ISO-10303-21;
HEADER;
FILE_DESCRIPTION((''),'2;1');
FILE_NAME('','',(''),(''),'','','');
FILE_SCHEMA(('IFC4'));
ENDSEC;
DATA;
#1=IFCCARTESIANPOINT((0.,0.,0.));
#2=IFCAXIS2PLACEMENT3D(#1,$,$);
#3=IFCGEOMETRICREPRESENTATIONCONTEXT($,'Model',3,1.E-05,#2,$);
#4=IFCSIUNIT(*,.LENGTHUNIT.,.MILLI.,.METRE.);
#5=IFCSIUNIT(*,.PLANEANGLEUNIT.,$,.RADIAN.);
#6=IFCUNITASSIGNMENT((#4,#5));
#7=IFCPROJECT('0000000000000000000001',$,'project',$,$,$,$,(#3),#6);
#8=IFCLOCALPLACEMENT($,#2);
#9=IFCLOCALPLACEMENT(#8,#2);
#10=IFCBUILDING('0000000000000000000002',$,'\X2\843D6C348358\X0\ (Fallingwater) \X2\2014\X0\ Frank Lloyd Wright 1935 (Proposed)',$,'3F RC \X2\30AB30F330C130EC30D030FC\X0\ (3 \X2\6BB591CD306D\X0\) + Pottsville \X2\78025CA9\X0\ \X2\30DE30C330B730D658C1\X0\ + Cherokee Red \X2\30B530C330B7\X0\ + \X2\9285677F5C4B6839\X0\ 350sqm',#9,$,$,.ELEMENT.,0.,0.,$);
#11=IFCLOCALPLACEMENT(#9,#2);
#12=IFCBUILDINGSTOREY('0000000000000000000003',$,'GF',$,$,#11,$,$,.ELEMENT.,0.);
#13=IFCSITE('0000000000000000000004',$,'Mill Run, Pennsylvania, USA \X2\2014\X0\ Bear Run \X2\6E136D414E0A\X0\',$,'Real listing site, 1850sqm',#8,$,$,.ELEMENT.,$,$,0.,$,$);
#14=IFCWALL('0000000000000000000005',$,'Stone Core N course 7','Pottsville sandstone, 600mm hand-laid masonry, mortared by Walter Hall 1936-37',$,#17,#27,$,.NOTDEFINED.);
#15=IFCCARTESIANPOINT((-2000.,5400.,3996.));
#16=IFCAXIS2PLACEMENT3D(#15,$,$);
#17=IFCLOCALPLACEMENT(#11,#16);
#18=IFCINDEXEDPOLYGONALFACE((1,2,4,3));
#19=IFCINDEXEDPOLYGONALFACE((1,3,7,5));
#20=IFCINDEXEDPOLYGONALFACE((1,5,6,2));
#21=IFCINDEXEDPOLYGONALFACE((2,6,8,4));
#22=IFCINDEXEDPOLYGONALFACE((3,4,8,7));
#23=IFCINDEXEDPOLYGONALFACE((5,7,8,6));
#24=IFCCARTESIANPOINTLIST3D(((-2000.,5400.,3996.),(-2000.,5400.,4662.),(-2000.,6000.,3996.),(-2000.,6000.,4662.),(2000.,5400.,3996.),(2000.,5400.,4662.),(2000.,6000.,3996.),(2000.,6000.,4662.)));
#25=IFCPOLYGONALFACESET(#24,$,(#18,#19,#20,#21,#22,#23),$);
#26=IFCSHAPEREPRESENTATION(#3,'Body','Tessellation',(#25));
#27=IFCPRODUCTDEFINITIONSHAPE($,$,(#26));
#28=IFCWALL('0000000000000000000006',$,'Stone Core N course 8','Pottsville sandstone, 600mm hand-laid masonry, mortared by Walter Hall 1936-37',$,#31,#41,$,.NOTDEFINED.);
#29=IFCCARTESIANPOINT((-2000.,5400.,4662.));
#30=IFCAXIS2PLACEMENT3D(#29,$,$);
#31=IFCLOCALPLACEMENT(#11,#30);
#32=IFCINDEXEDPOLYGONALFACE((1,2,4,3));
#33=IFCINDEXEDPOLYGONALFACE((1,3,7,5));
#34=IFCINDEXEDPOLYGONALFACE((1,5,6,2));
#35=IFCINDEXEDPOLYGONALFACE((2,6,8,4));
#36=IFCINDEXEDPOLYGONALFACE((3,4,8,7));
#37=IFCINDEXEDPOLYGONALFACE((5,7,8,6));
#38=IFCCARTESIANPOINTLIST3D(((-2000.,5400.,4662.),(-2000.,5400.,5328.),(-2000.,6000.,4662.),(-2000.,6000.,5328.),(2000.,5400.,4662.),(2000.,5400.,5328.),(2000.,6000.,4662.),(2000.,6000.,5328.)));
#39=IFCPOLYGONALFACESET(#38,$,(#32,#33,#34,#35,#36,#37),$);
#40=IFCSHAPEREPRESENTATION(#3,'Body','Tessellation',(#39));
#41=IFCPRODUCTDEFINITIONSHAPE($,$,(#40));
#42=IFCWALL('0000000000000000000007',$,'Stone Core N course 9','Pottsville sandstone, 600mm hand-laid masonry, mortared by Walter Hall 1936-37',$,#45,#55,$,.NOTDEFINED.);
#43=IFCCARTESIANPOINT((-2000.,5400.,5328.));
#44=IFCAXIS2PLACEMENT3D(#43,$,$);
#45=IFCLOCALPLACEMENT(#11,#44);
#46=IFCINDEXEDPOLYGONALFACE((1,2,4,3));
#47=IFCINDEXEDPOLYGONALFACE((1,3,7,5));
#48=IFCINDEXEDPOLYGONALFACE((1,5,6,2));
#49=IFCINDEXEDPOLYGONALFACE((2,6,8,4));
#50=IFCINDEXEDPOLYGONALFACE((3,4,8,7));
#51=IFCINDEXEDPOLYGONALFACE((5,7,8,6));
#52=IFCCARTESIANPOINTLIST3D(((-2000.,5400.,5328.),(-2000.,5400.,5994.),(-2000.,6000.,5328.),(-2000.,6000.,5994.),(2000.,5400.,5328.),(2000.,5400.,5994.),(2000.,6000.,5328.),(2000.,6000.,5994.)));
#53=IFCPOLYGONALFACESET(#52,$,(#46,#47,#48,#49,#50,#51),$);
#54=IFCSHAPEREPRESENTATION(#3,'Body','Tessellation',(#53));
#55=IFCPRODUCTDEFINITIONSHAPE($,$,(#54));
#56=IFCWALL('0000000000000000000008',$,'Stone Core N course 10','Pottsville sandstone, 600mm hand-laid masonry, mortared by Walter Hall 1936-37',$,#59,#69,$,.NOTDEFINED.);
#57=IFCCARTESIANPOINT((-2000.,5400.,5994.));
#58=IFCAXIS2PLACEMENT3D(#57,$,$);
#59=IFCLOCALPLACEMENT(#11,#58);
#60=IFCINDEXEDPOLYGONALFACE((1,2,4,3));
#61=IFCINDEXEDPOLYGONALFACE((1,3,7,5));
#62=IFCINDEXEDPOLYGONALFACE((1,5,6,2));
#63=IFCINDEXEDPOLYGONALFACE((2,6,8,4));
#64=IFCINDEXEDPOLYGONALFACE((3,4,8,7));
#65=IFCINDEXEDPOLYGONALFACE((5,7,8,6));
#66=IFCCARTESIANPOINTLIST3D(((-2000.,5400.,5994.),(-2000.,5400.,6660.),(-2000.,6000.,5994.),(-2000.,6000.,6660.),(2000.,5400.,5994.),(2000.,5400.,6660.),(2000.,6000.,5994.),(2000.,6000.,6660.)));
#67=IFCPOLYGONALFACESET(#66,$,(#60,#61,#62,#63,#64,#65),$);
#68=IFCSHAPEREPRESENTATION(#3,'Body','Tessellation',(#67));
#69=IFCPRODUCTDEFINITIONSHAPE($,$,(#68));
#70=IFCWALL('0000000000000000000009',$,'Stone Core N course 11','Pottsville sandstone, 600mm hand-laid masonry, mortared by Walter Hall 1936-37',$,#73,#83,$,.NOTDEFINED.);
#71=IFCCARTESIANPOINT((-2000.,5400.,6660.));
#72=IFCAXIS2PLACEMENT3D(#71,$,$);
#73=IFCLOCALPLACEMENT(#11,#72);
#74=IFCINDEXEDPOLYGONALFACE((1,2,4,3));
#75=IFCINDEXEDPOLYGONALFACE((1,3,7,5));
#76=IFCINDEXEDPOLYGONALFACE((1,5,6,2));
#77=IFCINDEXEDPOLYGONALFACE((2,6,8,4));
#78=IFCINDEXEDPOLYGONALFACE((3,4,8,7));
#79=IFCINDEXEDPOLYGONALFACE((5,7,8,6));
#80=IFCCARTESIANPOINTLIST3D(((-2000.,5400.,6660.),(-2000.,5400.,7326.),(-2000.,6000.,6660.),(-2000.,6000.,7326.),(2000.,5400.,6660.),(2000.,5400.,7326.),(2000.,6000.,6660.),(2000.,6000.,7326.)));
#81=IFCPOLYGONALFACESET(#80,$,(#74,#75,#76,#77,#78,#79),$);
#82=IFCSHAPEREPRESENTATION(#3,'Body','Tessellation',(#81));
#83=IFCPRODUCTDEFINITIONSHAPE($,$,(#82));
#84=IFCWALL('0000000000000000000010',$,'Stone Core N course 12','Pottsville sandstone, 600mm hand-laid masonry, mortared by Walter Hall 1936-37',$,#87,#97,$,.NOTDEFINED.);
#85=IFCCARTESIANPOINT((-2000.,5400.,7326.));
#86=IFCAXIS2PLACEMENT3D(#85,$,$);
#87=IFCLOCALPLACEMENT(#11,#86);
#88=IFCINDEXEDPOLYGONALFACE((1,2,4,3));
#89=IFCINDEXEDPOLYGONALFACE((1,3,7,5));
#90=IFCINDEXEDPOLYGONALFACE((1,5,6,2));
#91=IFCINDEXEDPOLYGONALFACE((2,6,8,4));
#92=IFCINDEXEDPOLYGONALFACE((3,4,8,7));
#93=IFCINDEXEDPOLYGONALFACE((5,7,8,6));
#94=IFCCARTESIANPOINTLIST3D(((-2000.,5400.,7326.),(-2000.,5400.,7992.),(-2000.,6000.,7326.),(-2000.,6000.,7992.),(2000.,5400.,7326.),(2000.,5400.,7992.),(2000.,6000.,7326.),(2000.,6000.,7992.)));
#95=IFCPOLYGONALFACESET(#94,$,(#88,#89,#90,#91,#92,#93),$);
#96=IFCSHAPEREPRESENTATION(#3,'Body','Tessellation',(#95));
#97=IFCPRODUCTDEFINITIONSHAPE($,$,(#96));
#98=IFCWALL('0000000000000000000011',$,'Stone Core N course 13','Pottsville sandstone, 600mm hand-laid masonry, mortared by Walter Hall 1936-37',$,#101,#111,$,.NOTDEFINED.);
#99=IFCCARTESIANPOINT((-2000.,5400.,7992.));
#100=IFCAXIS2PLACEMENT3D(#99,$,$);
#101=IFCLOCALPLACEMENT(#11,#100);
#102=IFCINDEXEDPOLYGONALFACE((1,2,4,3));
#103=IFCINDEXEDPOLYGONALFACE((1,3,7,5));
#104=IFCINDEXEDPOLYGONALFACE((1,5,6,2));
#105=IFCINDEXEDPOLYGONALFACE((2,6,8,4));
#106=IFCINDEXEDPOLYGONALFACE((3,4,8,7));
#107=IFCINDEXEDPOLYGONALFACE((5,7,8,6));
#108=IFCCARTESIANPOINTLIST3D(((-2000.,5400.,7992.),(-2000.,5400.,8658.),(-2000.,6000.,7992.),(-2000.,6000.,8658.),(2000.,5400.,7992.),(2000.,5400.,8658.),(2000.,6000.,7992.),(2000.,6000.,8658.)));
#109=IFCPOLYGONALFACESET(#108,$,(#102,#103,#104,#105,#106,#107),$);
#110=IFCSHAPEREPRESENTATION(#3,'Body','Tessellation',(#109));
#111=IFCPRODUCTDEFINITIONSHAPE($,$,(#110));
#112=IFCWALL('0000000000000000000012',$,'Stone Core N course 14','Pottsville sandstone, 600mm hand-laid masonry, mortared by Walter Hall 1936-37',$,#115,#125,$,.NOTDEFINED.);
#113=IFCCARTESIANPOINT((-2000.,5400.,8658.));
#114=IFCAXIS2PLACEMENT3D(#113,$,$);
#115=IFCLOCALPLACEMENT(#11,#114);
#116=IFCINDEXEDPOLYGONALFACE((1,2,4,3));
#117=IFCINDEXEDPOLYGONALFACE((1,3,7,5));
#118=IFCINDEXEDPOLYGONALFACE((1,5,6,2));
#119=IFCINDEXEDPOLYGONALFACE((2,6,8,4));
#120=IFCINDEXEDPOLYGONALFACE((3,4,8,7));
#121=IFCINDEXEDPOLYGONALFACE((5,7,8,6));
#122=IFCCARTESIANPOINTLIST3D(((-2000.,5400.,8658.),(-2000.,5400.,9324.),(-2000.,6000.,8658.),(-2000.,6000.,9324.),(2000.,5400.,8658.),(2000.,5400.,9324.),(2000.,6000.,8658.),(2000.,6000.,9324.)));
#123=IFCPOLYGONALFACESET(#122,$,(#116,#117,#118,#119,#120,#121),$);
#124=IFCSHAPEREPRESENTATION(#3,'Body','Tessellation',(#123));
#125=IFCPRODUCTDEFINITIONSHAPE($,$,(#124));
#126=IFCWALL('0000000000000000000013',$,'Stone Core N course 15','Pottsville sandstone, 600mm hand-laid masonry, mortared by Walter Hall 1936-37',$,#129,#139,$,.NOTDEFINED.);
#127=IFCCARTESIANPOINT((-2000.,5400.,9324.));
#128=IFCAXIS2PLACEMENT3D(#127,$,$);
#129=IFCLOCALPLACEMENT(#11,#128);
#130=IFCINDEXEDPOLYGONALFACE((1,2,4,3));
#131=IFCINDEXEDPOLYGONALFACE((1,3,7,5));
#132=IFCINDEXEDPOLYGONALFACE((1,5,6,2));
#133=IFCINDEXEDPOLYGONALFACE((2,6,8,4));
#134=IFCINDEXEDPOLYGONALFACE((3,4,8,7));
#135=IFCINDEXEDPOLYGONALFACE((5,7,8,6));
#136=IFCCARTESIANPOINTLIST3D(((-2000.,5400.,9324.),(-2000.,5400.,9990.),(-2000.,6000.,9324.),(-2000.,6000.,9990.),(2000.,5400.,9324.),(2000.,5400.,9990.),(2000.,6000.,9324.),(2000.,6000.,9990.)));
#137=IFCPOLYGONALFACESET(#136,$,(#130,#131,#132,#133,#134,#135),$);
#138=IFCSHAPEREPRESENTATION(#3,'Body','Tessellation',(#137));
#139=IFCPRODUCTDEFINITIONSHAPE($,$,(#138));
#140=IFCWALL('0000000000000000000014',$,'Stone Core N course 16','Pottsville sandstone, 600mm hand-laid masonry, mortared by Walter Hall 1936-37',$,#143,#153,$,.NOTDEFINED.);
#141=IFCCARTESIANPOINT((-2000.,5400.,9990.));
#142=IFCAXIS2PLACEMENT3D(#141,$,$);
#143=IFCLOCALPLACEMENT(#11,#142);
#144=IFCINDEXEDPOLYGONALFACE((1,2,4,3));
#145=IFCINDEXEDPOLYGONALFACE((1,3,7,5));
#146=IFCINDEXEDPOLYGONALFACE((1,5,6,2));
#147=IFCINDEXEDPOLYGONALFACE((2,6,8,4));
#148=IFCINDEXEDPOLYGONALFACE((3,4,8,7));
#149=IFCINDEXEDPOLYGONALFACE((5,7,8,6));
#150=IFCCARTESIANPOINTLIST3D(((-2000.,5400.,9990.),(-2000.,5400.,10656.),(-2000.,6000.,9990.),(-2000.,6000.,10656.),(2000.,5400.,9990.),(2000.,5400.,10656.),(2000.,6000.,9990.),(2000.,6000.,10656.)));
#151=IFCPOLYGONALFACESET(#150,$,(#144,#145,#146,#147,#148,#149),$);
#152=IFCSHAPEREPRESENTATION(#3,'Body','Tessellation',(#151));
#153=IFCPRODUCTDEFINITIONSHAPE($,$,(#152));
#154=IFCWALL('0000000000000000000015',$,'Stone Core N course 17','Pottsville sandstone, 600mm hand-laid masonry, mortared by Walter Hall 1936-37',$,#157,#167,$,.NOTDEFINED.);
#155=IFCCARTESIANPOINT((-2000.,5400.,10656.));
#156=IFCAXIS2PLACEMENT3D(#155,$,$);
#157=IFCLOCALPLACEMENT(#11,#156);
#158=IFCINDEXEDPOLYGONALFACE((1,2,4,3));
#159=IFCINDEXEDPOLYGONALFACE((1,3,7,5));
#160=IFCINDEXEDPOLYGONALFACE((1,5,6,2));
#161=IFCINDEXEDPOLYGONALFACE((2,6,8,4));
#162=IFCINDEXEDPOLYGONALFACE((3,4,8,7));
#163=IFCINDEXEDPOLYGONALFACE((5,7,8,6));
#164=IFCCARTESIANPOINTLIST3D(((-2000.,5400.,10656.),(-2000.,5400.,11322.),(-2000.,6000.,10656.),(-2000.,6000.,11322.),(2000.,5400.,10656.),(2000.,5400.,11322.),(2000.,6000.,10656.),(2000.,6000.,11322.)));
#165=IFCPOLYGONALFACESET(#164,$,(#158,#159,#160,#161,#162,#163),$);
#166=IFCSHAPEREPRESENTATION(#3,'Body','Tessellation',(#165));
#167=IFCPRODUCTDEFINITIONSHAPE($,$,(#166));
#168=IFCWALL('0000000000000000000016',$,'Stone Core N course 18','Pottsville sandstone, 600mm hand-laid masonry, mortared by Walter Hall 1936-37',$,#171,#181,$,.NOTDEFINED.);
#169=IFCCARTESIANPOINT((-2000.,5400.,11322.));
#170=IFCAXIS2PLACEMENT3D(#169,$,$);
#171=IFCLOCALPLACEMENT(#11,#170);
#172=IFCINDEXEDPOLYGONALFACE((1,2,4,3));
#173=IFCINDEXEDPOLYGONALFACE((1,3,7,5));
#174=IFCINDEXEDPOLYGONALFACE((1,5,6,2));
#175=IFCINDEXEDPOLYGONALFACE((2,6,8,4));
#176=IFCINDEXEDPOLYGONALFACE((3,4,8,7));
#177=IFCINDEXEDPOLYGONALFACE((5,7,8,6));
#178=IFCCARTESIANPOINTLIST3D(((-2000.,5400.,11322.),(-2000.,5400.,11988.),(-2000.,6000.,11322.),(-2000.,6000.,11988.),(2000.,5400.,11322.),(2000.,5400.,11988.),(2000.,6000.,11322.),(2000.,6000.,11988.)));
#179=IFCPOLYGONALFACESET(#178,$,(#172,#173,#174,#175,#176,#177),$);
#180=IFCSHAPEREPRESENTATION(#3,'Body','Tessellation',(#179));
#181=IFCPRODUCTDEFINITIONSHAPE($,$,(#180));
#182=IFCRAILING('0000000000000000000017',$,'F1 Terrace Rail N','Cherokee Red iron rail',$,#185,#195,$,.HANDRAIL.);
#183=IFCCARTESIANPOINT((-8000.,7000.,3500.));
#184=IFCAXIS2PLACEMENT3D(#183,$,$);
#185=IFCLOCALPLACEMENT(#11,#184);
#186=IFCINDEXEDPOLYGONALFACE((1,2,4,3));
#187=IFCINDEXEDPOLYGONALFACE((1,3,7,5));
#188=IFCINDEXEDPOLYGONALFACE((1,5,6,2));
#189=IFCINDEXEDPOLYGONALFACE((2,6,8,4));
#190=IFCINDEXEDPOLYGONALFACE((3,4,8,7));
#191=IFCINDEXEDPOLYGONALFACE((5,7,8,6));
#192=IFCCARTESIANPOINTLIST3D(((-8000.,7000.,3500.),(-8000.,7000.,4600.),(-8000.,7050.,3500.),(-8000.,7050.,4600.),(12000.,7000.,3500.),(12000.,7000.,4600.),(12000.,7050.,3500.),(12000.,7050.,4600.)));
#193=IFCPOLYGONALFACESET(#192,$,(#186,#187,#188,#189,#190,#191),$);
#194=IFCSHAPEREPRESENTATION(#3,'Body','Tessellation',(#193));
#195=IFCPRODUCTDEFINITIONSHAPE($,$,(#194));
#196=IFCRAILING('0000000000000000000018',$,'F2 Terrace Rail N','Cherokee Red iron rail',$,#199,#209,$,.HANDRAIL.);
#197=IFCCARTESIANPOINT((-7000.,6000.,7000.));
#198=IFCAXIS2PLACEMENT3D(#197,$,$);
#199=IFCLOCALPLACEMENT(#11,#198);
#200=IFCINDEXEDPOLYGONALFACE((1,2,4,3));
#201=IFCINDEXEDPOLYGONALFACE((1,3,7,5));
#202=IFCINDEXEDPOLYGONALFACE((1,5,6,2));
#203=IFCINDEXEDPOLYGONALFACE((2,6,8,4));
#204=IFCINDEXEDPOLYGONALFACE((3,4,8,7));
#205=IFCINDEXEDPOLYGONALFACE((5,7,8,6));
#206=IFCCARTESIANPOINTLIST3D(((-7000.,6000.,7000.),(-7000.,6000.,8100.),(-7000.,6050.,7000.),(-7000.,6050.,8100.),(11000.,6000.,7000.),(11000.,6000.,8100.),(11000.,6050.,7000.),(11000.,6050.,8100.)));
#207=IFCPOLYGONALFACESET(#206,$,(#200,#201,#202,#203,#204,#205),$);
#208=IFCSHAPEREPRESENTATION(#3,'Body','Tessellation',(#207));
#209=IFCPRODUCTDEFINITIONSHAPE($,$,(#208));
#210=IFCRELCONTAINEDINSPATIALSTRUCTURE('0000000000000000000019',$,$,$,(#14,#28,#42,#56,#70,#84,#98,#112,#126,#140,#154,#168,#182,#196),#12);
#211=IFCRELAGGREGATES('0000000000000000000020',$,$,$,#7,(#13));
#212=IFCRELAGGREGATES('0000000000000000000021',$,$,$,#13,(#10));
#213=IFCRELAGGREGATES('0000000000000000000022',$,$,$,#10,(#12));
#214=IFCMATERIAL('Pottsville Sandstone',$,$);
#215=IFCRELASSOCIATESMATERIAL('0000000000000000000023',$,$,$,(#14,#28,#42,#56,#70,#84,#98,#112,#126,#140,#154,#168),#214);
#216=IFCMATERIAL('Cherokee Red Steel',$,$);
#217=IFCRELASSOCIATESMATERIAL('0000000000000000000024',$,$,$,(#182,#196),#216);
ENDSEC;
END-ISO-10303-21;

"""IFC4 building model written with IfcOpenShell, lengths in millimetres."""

from ifc_helpers import new_model, si_unit, frame, frame_2d, origin, place, context, project, spatial, rectangle, extrude, material, element, save


model = new_model("IFC4")

# Units and contexts
model_context = context("Model", 3, precision=1e-05, world=origin())
ifc_project = project(units=[si_unit("LENGTHUNIT", "METRE", prefix="MILLI"), si_unit("PLANEANGLEUNIT", "RADIAN")], contexts=[model_context])

# Site, building, storey
site_placement = place(None, origin())
site = spatial("IfcSite", under=ifc_project, at=site_placement, Name="Mill Run, Pennsylvania, USA — Bear Run 渓流上", ObjectType="Real listing site, 1850sqm", CompositionType="ELEMENT", RefElevation=0.0)
building_placement = place(site_placement, origin())
building = spatial("IfcBuilding", under=site, at=building_placement, Name="落水荘 (Fallingwater) — Frank Lloyd Wright 1935 (Proposed)", ObjectType="3F RC カンチレバー (3 段重ね) + Pottsville 砂岩 マッシブ壁 + Cherokee Red サッシ + 銅板屋根 350sqm", CompositionType="ELEMENT", ElevationOfRefHeight=0.0, ElevationOfTerrain=0.0)
storey_placement = place(building_placement, origin())
storey = spatial("IfcBuildingStorey", under=building, at=storey_placement, Name="GF", CompositionType="ELEMENT", Elevation=0.0)

# Walls
ifc_material_1 = material(Name="Pottsville Sandstone")
wall_1_placement = place(storey_placement, frame((-2000.0, 5400.0, 3996.0)))
element("IfcWall", 1, at=wall_1_placement, inside=storey, material=ifc_material_1, Name="Stone Core N course 7", Description="Pottsville sandstone, 600mm hand-laid masonry, mortared by Walter Hall 1936-37", PredefinedType="NOTDEFINED", context=model_context, shape_type="SweptSolid", body=[
    extrude(rectangle(XDim=4000.0, YDim=600.0, at=frame_2d((2000.0, 300.0))), frame((-2000.0, 5400.0, 3996.0)), (0.0, 0.0, 1.0), 666.0),
])
wall_2_placement = place(storey_placement, frame((-2000.0, 5400.0, 4662.0)))
element("IfcWall", 2, at=wall_2_placement, inside=storey, material=ifc_material_1, Name="Stone Core N course 8", Description="Pottsville sandstone, 600mm hand-laid masonry, mortared by Walter Hall 1936-37", PredefinedType="NOTDEFINED", context=model_context, shape_type="SweptSolid", body=[
    extrude(rectangle(XDim=4000.0, YDim=600.0, at=frame_2d((2000.0, 300.0))), frame((-2000.0, 5400.0, 4662.0)), (0.0, 0.0, 1.0), 666.0),
])
wall_3_placement = place(storey_placement, frame((-2000.0, 5400.0, 5328.0)))
element("IfcWall", 3, at=wall_3_placement, inside=storey, material=ifc_material_1, Name="Stone Core N course 9", Description="Pottsville sandstone, 600mm hand-laid masonry, mortared by Walter Hall 1936-37", PredefinedType="NOTDEFINED", context=model_context, shape_type="SweptSolid", body=[
    extrude(rectangle(XDim=4000.0, YDim=600.0, at=frame_2d((2000.0, 300.0))), frame((-2000.0, 5400.0, 5328.0)), (0.0, 0.0, 1.0), 666.0),
])
wall_4_placement = place(storey_placement, frame((-2000.0, 5400.0, 5994.0)))
element("IfcWall", 4, at=wall_4_placement, inside=storey, material=ifc_material_1, Name="Stone Core N course 10", Description="Pottsville sandstone, 600mm hand-laid masonry, mortared by Walter Hall 1936-37", PredefinedType="NOTDEFINED", context=model_context, shape_type="SweptSolid", body=[
    extrude(rectangle(XDim=4000.0, YDim=600.0, at=frame_2d((2000.0, 300.0))), frame((-2000.0, 5400.0, 5994.0)), (0.0, 0.0, 1.0), 666.0),
])
wall_5_placement = place(storey_placement, frame((-2000.0, 5400.0, 6660.0)))
element("IfcWall", 5, at=wall_5_placement, inside=storey, material=ifc_material_1, Name="Stone Core N course 11", Description="Pottsville sandstone, 600mm hand-laid masonry, mortared by Walter Hall 1936-37", PredefinedType="NOTDEFINED", context=model_context, shape_type="SweptSolid", body=[
    extrude(rectangle(XDim=4000.0, YDim=600.0, at=frame_2d((2000.0, 300.0))), frame((-2000.0, 5400.0, 6660.0)), (0.0, 0.0, 1.0), 666.0),
])
wall_6_placement = place(storey_placement, frame((-2000.0, 5400.0, 7326.0)))
element("IfcWall", 6, at=wall_6_placement, inside=storey, material=ifc_material_1, Name="Stone Core N course 12", Description="Pottsville sandstone, 600mm hand-laid masonry, mortared by Walter Hall 1936-37", PredefinedType="NOTDEFINED", context=model_context, shape_type="SweptSolid", body=[
    extrude(rectangle(XDim=4000.0, YDim=600.0, at=frame_2d((2000.0, 300.0))), frame((-2000.0, 5400.0, 7326.0)), (0.0, 0.0, 1.0), 666.0),
])
wall_7_placement = place(storey_placement, frame((-2000.0, 5400.0, 7992.0)))
element("IfcWall", 7, at=wall_7_placement, inside=storey, material=ifc_material_1, Name="Stone Core N course 13", Description="Pottsville sandstone, 600mm hand-laid masonry, mortared by Walter Hall 1936-37", PredefinedType="NOTDEFINED", context=model_context, shape_type="SweptSolid", body=[
    extrude(rectangle(XDim=4000.0, YDim=600.0, at=frame_2d((2000.0, 300.0))), frame((-2000.0, 5400.0, 7992.0)), (0.0, 0.0, 1.0), 666.0),
])
wall_8_placement = place(storey_placement, frame((-2000.0, 5400.0, 8658.0)))
element("IfcWall", 8, at=wall_8_placement, inside=storey, material=ifc_material_1, Name="Stone Core N course 14", Description="Pottsville sandstone, 600mm hand-laid masonry, mortared by Walter Hall 1936-37", PredefinedType="NOTDEFINED", context=model_context, shape_type="SweptSolid", body=[
    extrude(rectangle(XDim=4000.0, YDim=600.0, at=frame_2d((2000.0, 300.0))), frame((-2000.0, 5400.0, 8658.0)), (0.0, 0.0, 1.0), 666.0),
])
wall_9_placement = place(storey_placement, frame((-2000.0, 5400.0, 9324.0)))
element("IfcWall", 9, at=wall_9_placement, inside=storey, material=ifc_material_1, Name="Stone Core N course 15", Description="Pottsville sandstone, 600mm hand-laid masonry, mortared by Walter Hall 1936-37", PredefinedType="NOTDEFINED", context=model_context, shape_type="SweptSolid", body=[
    extrude(rectangle(XDim=4000.0, YDim=600.0, at=frame_2d((2000.0, 300.0))), frame((-2000.0, 5400.0, 9324.0)), (0.0, 0.0, 1.0), 666.0),
])
wall_10_placement = place(storey_placement, frame((-2000.0, 5400.0, 9990.0)))
element("IfcWall", 10, at=wall_10_placement, inside=storey, material=ifc_material_1, Name="Stone Core N course 16", Description="Pottsville sandstone, 600mm hand-laid masonry, mortared by Walter Hall 1936-37", PredefinedType="NOTDEFINED", context=model_context, shape_type="SweptSolid", body=[
    extrude(rectangle(XDim=4000.0, YDim=600.0, at=frame_2d((2000.0, 300.0))), frame((-2000.0, 5400.0, 9990.0)), (0.0, 0.0, 1.0), 666.0),
])
wall_11_placement = place(storey_placement, frame((-2000.0, 5400.0, 10656.0)))
element("IfcWall", 11, at=wall_11_placement, inside=storey, material=ifc_material_1, Name="Stone Core N course 17", Description="Pottsville sandstone, 600mm hand-laid masonry, mortared by Walter Hall 1936-37", PredefinedType="NOTDEFINED", context=model_context, shape_type="SweptSolid", body=[
    extrude(rectangle(XDim=4000.0, YDim=600.0, at=frame_2d((2000.0, 300.0))), frame((-2000.0, 5400.0, 10656.0)), (0.0, 0.0, 1.0), 666.0),
])
wall_12_placement = place(storey_placement, frame((-2000.0, 5400.0, 11322.0)))
element("IfcWall", 12, at=wall_12_placement, inside=storey, material=ifc_material_1, Name="Stone Core N course 18", Description="Pottsville sandstone, 600mm hand-laid masonry, mortared by Walter Hall 1936-37", PredefinedType="NOTDEFINED", context=model_context, shape_type="SweptSolid", body=[
    extrude(rectangle(XDim=4000.0, YDim=600.0, at=frame_2d((2000.0, 300.0))), frame((-2000.0, 5400.0, 11322.0)), (0.0, 0.0, 1.0), 666.0),
])

# Railings
ifc_material_2 = material(Name="Cherokee Red Steel")
railing_1_placement = place(storey_placement, frame((-8000.0, 7000.0, 3500.0)))
element("IfcRailing", 13, at=railing_1_placement, inside=storey, material=ifc_material_2, Name="F1 Terrace Rail N", Description="Cherokee Red iron rail", PredefinedType="HANDRAIL", context=model_context, shape_type="SweptSolid", body=[
    extrude(rectangle(XDim=20000.0, YDim=50.0, at=frame_2d((10000.0, 25.0))), frame((-8000.0, 7000.0, 3500.0)), (0.0, 0.0, 1.0), 1100.0),
])
railing_2_placement = place(storey_placement, frame((-7000.0, 6000.0, 7000.0)))
element("IfcRailing", 14, at=railing_2_placement, inside=storey, material=ifc_material_2, Name="F2 Terrace Rail N", Description="Cherokee Red iron rail", PredefinedType="HANDRAIL", context=model_context, shape_type="SweptSolid", body=[
    extrude(rectangle(XDim=18000.0, YDim=50.0, at=frame_2d((9000.0, 25.0))), frame((-7000.0, 6000.0, 7000.0)), (0.0, 0.0, 1.0), 1100.0),
])

save(model, "model.ifc")
